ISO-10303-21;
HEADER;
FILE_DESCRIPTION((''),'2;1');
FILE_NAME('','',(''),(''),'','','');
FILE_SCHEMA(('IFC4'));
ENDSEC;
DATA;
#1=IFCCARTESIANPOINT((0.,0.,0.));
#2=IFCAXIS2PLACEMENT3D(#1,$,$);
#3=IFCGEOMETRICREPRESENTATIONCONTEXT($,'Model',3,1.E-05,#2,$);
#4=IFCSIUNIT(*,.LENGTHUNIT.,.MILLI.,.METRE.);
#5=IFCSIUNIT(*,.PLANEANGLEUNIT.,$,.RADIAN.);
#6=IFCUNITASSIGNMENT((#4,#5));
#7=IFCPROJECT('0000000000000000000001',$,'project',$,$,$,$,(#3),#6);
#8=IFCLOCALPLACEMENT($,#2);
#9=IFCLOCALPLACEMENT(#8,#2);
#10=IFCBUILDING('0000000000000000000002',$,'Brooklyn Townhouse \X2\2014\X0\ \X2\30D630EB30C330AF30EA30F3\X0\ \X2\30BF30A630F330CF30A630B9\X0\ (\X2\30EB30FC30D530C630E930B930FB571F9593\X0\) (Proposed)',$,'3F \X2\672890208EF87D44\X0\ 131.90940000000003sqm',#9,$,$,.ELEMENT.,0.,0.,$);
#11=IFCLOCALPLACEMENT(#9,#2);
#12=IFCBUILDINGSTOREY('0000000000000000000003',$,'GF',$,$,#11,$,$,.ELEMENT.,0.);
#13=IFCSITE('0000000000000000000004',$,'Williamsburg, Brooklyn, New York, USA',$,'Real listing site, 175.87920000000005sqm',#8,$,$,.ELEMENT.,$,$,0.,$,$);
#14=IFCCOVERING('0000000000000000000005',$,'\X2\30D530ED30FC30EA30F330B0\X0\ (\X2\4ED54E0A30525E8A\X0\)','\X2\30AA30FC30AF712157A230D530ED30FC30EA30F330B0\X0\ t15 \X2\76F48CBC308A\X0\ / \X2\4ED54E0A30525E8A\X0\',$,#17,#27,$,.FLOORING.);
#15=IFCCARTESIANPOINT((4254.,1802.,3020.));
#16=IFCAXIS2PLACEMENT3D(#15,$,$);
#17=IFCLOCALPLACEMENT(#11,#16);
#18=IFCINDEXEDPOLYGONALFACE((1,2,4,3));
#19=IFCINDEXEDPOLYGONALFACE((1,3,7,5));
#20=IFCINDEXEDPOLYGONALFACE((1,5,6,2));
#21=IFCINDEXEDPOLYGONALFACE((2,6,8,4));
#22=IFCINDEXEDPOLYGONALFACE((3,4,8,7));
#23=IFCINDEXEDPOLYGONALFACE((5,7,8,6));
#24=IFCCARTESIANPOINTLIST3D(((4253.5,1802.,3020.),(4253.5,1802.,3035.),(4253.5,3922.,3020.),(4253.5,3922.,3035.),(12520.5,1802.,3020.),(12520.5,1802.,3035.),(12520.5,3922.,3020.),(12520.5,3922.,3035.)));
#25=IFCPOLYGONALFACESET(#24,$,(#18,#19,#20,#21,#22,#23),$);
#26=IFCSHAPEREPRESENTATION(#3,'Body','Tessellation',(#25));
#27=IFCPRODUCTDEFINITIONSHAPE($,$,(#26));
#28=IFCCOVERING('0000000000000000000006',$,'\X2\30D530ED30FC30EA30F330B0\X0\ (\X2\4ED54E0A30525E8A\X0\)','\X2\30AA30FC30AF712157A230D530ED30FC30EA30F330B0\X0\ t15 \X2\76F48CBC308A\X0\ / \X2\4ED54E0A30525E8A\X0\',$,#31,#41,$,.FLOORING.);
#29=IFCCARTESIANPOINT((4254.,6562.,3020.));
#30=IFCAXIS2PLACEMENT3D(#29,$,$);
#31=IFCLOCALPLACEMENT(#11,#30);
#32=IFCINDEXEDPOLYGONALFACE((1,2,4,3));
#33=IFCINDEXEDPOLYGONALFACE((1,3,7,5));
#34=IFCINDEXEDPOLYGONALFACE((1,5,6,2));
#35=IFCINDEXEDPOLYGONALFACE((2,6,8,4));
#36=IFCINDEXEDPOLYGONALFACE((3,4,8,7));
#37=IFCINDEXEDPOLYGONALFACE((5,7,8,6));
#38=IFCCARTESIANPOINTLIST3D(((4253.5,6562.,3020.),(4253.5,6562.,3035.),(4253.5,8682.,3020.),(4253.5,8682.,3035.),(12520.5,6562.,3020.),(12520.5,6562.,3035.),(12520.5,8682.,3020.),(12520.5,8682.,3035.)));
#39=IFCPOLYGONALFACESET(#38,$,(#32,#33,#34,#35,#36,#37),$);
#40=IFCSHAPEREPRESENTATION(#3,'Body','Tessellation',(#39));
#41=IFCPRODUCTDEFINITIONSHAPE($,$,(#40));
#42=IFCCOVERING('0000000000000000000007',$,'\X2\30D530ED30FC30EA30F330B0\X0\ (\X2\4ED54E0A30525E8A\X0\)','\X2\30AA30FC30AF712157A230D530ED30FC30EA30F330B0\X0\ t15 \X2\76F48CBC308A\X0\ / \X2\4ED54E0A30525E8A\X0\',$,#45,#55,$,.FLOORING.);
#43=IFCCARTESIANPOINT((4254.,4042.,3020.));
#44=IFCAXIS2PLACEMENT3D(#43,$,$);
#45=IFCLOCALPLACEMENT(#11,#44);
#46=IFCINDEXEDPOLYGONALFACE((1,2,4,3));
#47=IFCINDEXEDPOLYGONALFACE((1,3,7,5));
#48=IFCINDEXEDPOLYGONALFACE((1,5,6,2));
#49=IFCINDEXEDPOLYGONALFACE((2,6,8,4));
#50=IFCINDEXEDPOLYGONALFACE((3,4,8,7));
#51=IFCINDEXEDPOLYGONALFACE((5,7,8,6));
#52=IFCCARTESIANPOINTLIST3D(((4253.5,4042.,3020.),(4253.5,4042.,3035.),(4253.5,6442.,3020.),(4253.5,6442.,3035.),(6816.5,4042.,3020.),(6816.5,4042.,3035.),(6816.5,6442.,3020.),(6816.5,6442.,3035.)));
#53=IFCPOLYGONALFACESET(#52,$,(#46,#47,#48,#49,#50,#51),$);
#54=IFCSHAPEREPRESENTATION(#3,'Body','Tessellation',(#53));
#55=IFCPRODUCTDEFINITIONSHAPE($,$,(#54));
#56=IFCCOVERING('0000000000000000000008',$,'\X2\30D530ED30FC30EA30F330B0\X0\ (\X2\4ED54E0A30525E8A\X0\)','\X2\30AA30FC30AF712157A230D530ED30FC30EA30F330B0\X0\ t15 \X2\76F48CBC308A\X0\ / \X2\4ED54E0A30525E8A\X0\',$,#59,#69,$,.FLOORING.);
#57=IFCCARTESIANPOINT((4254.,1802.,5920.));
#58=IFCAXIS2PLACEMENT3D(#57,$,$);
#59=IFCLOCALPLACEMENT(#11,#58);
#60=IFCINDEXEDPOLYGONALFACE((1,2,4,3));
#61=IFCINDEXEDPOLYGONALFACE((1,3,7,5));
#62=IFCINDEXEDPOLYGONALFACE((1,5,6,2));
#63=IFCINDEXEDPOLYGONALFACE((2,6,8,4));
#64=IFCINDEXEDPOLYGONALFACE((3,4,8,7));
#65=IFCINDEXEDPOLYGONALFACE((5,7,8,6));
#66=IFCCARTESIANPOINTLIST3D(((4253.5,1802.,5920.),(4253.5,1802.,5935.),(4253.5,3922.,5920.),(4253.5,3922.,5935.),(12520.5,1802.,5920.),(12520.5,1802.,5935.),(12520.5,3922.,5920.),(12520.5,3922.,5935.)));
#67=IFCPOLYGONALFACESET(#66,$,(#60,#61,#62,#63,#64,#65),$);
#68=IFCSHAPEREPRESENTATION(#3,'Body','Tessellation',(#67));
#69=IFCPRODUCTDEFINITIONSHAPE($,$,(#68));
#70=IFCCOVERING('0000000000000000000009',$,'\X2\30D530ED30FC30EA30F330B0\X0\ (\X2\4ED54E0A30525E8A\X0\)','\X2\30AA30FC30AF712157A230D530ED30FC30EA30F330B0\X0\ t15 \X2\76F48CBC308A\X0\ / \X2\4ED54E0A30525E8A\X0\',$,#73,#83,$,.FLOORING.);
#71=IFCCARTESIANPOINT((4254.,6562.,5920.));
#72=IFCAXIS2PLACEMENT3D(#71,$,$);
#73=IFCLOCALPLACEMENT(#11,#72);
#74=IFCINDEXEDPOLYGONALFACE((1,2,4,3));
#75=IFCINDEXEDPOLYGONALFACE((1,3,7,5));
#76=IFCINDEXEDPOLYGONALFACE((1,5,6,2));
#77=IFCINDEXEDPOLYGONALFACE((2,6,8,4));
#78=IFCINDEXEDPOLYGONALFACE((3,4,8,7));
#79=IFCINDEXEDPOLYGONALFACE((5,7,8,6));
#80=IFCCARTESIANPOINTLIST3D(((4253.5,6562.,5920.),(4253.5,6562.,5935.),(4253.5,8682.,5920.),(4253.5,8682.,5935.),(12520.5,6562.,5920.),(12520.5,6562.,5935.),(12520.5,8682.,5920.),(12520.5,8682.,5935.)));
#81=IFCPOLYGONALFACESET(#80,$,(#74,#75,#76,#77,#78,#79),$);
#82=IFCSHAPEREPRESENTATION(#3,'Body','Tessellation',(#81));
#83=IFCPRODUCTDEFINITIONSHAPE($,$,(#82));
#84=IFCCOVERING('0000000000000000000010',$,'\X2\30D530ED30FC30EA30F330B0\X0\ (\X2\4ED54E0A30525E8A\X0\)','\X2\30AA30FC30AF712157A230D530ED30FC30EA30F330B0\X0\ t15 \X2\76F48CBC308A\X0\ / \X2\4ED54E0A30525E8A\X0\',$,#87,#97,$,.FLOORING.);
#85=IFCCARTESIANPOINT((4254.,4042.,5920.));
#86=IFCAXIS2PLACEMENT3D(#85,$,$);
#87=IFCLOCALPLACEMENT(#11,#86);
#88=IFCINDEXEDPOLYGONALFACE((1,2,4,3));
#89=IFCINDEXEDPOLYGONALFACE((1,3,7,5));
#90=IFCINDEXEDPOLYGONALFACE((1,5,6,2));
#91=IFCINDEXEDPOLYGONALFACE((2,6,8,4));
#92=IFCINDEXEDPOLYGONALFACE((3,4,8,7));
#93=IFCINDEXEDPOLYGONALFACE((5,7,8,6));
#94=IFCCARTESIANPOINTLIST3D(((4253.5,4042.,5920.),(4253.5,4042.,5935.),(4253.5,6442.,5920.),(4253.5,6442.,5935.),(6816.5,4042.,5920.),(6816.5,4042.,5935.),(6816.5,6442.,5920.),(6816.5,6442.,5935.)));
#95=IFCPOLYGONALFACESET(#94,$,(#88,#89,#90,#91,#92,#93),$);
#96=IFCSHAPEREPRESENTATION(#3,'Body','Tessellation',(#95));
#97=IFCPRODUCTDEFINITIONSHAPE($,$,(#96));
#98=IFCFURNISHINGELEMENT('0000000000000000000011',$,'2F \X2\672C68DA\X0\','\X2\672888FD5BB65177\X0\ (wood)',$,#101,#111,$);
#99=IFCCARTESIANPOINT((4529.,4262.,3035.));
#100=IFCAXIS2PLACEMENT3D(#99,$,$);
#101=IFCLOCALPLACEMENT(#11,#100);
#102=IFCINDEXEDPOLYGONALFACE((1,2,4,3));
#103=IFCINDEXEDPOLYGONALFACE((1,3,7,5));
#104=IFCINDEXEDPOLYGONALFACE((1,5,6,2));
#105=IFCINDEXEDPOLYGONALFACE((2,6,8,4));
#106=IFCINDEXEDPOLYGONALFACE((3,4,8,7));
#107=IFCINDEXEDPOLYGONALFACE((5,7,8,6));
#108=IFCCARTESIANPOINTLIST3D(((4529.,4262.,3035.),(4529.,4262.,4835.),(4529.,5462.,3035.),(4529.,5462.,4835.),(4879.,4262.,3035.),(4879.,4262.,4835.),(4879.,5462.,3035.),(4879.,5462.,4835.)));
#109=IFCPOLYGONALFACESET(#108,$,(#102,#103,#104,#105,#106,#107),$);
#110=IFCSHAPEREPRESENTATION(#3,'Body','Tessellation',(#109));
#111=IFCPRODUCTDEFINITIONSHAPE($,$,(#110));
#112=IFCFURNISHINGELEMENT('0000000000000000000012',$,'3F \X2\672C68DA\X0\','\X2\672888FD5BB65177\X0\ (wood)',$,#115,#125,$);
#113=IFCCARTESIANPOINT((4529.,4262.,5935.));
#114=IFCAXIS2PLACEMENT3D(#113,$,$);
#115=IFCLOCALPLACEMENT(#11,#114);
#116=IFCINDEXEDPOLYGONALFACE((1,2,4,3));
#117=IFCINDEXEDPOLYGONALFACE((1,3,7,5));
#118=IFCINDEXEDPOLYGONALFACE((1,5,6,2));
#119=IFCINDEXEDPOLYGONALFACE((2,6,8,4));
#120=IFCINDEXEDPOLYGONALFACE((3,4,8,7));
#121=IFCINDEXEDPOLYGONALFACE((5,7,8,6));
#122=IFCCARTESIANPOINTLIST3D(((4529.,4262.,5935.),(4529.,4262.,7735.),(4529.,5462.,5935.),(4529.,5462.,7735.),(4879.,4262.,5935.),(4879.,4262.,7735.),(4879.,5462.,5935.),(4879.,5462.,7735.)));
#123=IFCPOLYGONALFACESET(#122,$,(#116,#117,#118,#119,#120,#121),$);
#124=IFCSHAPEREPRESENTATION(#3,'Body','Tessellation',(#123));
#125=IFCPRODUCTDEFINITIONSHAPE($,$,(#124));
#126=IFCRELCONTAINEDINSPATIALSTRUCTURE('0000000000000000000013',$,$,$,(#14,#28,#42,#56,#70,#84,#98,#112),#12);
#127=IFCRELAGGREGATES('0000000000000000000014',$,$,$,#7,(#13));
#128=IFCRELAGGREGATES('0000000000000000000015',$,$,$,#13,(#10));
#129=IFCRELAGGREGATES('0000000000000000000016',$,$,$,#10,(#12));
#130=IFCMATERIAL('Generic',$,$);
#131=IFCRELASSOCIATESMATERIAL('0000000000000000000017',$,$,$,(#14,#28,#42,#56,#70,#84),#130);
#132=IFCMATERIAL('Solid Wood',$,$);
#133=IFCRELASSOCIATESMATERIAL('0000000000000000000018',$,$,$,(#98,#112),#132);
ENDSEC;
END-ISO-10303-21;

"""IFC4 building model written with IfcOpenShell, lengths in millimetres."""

from ifc_helpers import new_model, si_unit, frame, frame_2d, origin, place, context, project, spatial, rectangle, extrude, material, element, save


model = new_model("IFC4")

# Units and contexts
model_context = context("Model", 3, precision=1e-05, world=origin())
ifc_project = project(units=[si_unit("LENGTHUNIT", "METRE", prefix="MILLI"), si_unit("PLANEANGLEUNIT", "RADIAN")], contexts=[model_context])

# Site, building, storey
site_placement = place(None, origin())
site = spatial("IfcSite", under=ifc_project, at=site_placement, Name="Williamsburg, Brooklyn, New York, USA", ObjectType="Real listing site, 175.87920000000005sqm", CompositionType="ELEMENT", RefElevation=0.0)
building_placement = place(site_placement, origin())
building = spatial("IfcBuilding", under=site, at=building_placement, Name="Brooklyn Townhouse — ブルックリン タウンハウス (ルーフテラス・土間) (Proposed)", ObjectType="3F 木造軸組 131.90940000000003sqm", CompositionType="ELEMENT", ElevationOfRefHeight=0.0, ElevationOfTerrain=0.0)
storey_placement = place(building_placement, origin())
storey = spatial("IfcBuildingStorey", under=building, at=storey_placement, Name="GF", CompositionType="ELEMENT", Elevation=0.0)

# Shared definitions
ifc_material_1 = material(Name="Solid Wood")

# Coverings
ifc_material_2 = material(Name="Generic")
covering_1_placement = place(storey_placement, frame((4254.0, 1802.0, 3020.0)))
element("IfcCovering", 1, at=covering_1_placement, inside=storey, material=ifc_material_2, Name="フローリング (仕上げ床)", Description="オーク無垢フローリング t15 直貼り / 仕上げ床", PredefinedType="FLOORING", context=model_context, shape_type="SweptSolid", body=[
    extrude(rectangle(XDim=8267.0, YDim=2120.0, at=frame_2d((4133.0, 1060.0))), frame((4254.0, 1802.0, 3020.0)), (0.0, 0.0, 1.0), 15.0),
])
covering_2_placement = place(storey_placement, frame((4254.0, 6562.0, 3020.0)))
element("IfcCovering", 2, at=covering_2_placement, inside=storey, material=ifc_material_2, Name="フローリング (仕上げ床)", Description="オーク無垢フローリング t15 直貼り / 仕上げ床", PredefinedType="FLOORING", context=model_context, shape_type="SweptSolid", body=[
    extrude(rectangle(XDim=8267.0, YDim=2120.0, at=frame_2d((4133.0, 1060.0))), frame((4254.0, 6562.0, 3020.0)), (0.0, 0.0, 1.0), 15.0),
])
covering_3_placement = place(storey_placement, frame((4254.0, 4042.0, 3020.0)))
element("IfcCovering", 3, at=covering_3_placement, inside=storey, material=ifc_material_2, Name="フローリング (仕上げ床)", Description="オーク無垢フローリング t15 直貼り / 仕上げ床", PredefinedType="FLOORING", context=model_context, shape_type="SweptSolid", body=[
    extrude(rectangle(XDim=2563.0, YDim=2400.0, at=frame_2d((1281.0, 1200.0))), frame((4254.0, 4042.0, 3020.0)), (0.0, 0.0, 1.0), 15.0),
])
covering_4_placement = place(storey_placement, frame((4254.0, 1802.0, 5920.0)))
element("IfcCovering", 4, at=covering_4_placement, inside=storey, material=ifc_material_2, Name="フローリング (仕上げ床)", Description="オーク無垢フローリング t15 直貼り / 仕上げ床", PredefinedType="FLOORING", context=model_context, shape_type="SweptSolid", body=[
    extrude(rectangle(XDim=8267.0, YDim=2120.0, at=frame_2d((4133.0, 1060.0))), frame((4254.0, 1802.0, 5920.0)), (0.0, 0.0, 1.0), 15.0),
])
covering_5_placement = place(storey_placement, frame((4254.0, 6562.0, 5920.0)))
element("IfcCovering", 5, at=covering_5_placement, inside=storey, material=ifc_material_2, Name="フローリング (仕上げ床)", Description="オーク無垢フローリング t15 直貼り / 仕上げ床", PredefinedType="FLOORING", context=model_context, shape_type="SweptSolid", body=[
    extrude(rectangle(XDim=8267.0, YDim=2120.0, at=frame_2d((4133.0, 1060.0))), frame((4254.0, 6562.0, 5920.0)), (0.0, 0.0, 1.0), 15.0),
])
covering_6_placement = place(storey_placement, frame((4254.0, 4042.0, 5920.0)))
element("IfcCovering", 6, at=covering_6_placement, inside=storey, material=ifc_material_2, Name="フローリング (仕上げ床)", Description="オーク無垢フローリング t15 直貼り / 仕上げ床", PredefinedType="FLOORING", context=model_context, shape_type="SweptSolid", body=[
    extrude(rectangle(XDim=2563.0, YDim=2400.0, at=frame_2d((1281.0, 1200.0))), frame((4254.0, 4042.0, 5920.0)), (0.0, 0.0, 1.0), 15.0),
])

# Furnishing elements
furnishing_1_placement = place(storey_placement, frame((4529.0, 4262.0, 3035.0)))
element("IfcFurnishingElement", 7, at=furnishing_1_placement, inside=storey, material=ifc_material_1, Name="2F 本棚", Description="木製家具 (wood)", context=model_context, shape_type="SweptSolid", body=[
    extrude(rectangle(XDim=350.0, YDim=1200.0, at=frame_2d((175.0, 600.0))), frame((4529.0, 4262.0, 3035.0)), (0.0, 0.0, 1.0), 1800.0),
])
furnishing_2_placement = place(storey_placement, frame((4529.0, 4262.0, 5935.0)))
element("IfcFurnishingElement", 8, at=furnishing_2_placement, inside=storey, material=ifc_material_1, Name="3F 本棚", Description="木製家具 (wood)", context=model_context, shape_type="SweptSolid", body=[
    extrude(rectangle(XDim=350.0, YDim=1200.0, at=frame_2d((175.0, 600.0))), frame((4529.0, 4262.0, 5935.0)), (0.0, 0.0, 1.0), 1800.0),
])

save(model, "model.ifc")
